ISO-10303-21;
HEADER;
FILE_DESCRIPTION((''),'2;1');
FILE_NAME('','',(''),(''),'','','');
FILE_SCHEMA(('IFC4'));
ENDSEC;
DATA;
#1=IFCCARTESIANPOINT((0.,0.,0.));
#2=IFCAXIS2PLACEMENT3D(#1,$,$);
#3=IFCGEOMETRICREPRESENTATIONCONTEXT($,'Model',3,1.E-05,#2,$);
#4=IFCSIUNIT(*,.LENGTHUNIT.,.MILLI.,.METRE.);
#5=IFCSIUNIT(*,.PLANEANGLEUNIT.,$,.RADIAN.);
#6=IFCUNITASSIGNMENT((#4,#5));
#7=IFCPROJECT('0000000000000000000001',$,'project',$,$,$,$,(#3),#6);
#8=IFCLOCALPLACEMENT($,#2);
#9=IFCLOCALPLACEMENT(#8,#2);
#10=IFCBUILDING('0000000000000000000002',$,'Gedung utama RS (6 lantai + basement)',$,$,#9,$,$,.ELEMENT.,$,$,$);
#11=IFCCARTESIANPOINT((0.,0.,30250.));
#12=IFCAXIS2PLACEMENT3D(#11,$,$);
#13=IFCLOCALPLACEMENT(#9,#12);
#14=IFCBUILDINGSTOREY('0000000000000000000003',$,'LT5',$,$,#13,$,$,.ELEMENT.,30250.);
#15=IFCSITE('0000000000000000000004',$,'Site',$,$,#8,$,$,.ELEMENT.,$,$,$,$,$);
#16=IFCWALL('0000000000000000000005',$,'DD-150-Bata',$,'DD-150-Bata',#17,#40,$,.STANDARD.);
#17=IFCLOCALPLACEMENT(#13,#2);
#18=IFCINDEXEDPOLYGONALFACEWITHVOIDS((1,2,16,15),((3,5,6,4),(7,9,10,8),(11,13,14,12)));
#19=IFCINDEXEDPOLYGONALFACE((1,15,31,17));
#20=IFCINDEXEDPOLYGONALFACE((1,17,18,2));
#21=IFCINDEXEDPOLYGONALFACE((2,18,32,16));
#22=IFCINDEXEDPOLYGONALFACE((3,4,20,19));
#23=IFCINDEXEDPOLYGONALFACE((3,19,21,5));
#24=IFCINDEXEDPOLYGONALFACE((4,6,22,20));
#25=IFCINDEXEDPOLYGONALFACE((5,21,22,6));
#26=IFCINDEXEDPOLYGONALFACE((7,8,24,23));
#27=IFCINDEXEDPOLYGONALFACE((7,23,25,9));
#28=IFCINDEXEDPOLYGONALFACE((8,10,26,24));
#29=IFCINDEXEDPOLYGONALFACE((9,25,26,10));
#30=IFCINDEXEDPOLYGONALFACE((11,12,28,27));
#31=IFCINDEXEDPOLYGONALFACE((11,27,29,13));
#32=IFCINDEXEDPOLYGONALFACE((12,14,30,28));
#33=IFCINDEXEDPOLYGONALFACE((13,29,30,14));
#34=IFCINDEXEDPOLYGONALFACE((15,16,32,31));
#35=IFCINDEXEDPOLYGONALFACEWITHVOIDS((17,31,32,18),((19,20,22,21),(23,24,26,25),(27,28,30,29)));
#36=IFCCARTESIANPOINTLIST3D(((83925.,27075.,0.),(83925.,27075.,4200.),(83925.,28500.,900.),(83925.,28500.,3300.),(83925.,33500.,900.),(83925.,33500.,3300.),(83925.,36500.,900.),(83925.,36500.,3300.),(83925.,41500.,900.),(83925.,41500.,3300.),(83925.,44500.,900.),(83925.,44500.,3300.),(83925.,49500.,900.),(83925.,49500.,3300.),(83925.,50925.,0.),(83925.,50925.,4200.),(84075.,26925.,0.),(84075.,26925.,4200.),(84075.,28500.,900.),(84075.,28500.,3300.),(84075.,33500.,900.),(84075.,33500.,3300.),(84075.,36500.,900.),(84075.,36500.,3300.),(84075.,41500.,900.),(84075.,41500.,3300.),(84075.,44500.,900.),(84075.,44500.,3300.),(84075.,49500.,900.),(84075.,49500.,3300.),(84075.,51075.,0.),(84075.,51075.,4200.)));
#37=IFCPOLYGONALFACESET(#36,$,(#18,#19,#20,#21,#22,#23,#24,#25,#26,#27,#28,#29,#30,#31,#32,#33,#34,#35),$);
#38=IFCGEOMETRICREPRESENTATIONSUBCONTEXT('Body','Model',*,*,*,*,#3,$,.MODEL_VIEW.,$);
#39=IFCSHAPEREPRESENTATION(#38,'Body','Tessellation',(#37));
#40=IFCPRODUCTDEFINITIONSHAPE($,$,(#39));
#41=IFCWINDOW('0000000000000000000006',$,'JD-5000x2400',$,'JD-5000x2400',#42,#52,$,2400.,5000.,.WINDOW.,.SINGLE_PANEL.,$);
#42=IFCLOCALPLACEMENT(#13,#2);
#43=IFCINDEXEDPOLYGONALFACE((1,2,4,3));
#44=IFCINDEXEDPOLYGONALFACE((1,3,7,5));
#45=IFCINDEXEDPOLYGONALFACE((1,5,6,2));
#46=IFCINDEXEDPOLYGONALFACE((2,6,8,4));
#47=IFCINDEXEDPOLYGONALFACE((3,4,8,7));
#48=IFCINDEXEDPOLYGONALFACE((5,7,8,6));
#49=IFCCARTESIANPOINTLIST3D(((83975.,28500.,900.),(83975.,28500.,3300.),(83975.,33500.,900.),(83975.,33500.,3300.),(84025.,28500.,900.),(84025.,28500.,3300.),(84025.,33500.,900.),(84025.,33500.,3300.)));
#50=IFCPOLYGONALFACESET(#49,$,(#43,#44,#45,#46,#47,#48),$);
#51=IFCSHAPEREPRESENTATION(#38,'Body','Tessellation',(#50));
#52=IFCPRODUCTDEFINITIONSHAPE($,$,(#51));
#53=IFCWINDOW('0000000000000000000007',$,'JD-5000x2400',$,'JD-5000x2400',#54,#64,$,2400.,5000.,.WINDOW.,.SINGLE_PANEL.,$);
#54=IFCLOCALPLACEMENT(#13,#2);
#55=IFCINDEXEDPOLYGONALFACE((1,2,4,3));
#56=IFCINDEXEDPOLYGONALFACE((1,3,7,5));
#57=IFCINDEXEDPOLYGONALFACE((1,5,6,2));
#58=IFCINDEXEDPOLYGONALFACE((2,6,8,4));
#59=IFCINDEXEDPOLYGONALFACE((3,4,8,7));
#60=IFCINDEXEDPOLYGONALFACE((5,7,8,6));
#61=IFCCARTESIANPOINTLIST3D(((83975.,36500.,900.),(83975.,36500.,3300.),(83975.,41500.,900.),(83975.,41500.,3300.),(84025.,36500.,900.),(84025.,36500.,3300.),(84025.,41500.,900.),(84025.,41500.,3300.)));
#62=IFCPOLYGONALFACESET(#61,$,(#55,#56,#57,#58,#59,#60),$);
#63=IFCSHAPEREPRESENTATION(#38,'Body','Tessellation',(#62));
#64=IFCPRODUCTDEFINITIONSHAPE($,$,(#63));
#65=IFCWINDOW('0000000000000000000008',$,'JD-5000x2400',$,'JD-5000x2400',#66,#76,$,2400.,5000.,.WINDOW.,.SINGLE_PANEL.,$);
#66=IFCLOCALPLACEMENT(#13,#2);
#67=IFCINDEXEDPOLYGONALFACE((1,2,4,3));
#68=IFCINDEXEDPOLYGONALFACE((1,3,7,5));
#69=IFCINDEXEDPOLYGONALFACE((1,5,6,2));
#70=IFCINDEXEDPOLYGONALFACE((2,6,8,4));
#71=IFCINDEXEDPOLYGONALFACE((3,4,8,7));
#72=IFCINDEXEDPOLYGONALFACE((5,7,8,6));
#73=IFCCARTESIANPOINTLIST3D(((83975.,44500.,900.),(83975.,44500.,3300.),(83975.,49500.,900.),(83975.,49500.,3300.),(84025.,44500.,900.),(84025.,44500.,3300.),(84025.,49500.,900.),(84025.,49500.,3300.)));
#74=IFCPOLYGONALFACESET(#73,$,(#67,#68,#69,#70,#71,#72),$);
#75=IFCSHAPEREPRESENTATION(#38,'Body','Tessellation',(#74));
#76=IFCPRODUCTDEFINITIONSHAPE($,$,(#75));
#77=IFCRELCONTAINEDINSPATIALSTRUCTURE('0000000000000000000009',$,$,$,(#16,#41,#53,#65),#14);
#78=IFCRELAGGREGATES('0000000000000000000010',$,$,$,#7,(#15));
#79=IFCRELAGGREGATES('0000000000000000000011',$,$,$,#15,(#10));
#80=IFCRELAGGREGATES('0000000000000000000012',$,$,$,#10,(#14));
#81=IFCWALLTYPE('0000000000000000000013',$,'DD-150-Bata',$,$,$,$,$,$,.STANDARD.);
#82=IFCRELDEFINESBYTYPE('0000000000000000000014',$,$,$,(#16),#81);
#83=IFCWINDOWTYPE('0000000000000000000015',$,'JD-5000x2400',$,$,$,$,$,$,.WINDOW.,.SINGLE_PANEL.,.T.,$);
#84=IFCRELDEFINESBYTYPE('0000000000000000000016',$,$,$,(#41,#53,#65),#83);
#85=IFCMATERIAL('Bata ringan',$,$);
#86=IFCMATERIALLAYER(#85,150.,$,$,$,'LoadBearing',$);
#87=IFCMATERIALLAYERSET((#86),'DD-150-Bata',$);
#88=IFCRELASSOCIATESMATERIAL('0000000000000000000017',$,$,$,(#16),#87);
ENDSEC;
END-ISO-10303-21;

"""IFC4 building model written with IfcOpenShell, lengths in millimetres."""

from ifc_helpers import new_model, si_unit, frame, frame_2d, origin, place, context, subcontext, project, spatial, polyline, rectangle, outline, extrude, material, layer, layer_set, layer_usage, type_object, element, fill, save


model = new_model("IFC4")

# Units and contexts
model_context = context("Model", 3, precision=1e-05, world=origin())
body_context = subcontext(model_context, "Body", "Model", "MODEL_VIEW")
ifc_project = project(units=[si_unit("LENGTHUNIT", "METRE", prefix="MILLI"), si_unit("PLANEANGLEUNIT", "RADIAN")], contexts=[model_context])

# Site, building, storey
site_placement = place(None, origin())
site = spatial("IfcSite", under=ifc_project, at=site_placement, Name="Site", CompositionType="ELEMENT")
building_placement = place(site_placement, origin())
building = spatial("IfcBuilding", under=site, at=building_placement, Name="Gedung utama RS (6 lantai + basement)", CompositionType="ELEMENT")
storey_placement = place(building_placement, frame((0.0, 0.0, 30250.0)))
storey = spatial("IfcBuildingStorey", under=building, at=storey_placement, Name="LT5", CompositionType="ELEMENT", Elevation=30250.0)

# Wall, openings, windows
ifc_material_1 = material(Name="Bata ringan")
ifc_layer = layer(ifc_material_1, 150.0, Category="LoadBearing")
ifc_layer_set = layer_set([ifc_layer], Name="DD-150-Bata")
ifc_layer_usage = layer_usage(ifc_layer_set, "AXIS2", "NEGATIVE", 75.0)
wall_type = type_object("IfcWallType", Name="DD-150-Bata", PredefinedType="STANDARD")
wall_1_placement = place(storey_placement, frame((84000.0, 27000.0, 0.0), z_axis=(0.0, 0.0, 1.0), x_axis=(0.0, 1.0, 0.0)))
wall_1 = element("IfcWall", 1, at=wall_1_placement, inside=storey, type_object=wall_type, material=ifc_layer_usage, Name="DD-150-Bata", ObjectType="DD-150-Bata", PredefinedType="STANDARD", context=body_context, shape_type="SweptSolid", body=[
    extrude(outline(polyline([(-75.0, -75.0), (0.0, 0.0), (75.0, 75.0), (23925.0, 75.0), (24000.0, 0.0), (24075.0, -75.0), (-75.0, -75.0)])), origin(), (0.0, 0.0, 1.0), 4200.0),
])
opening_1_placement = place(wall_1_placement, frame((1500.0, 0.0, 900.0), z_axis=(0.0, 0.0, 1.0), x_axis=(1.0, 0.0, 0.0)))
opening_1 = element("IfcOpeningElement", 2, at=opening_1_placement, cuts=wall_1, PredefinedType="OPENING", context=body_context, shape_type="SweptSolid", body=[
    extrude(rectangle(XDim=5000.0, YDim=170.0, at=frame_2d((2500.0, 0.0))), origin(), (0.0, 0.0, 1.0), 2400.0),
])
opening_2_placement = place(wall_1_placement, frame((9500.0, 0.0, 900.0), z_axis=(0.0, 0.0, 1.0), x_axis=(1.0, 0.0, 0.0)))
opening_2 = element("IfcOpeningElement", 3, at=opening_2_placement, cuts=wall_1, PredefinedType="OPENING", context=body_context, shape_type="SweptSolid", body=[
    extrude(rectangle(XDim=5000.0, YDim=170.0, at=frame_2d((2500.0, 0.0))), origin(), (0.0, 0.0, 1.0), 2400.0),
])
opening_3_placement = place(wall_1_placement, frame((17500.0, 0.0, 900.0), z_axis=(0.0, 0.0, 1.0), x_axis=(1.0, 0.0, 0.0)))
opening_3 = element("IfcOpeningElement", 4, at=opening_3_placement, cuts=wall_1, PredefinedType="OPENING", context=body_context, shape_type="SweptSolid", body=[
    extrude(rectangle(XDim=5000.0, YDim=170.0, at=frame_2d((2500.0, 0.0))), origin(), (0.0, 0.0, 1.0), 2400.0),
])
window_type = type_object("IfcWindowType", Name="JD-5000x2400", ParameterTakesPrecedence=True, PartitioningType="SINGLE_PANEL", PredefinedType="WINDOW")
window_1_placement = place(opening_1_placement, origin())
window_1 = element("IfcWindow", 5, at=window_1_placement, inside=storey, type_object=window_type, Name="JD-5000x2400", ObjectType="JD-5000x2400", OverallHeight=2400.0, OverallWidth=5000.0, PartitioningType="SINGLE_PANEL", PredefinedType="WINDOW", context=body_context, shape_type="SweptSolid", body=[
    extrude(rectangle(XDim=5000.0, YDim=50.0, at=frame_2d((2500.0, 0.0))), origin(), (0.0, 0.0, 1.0), 2400.0),
])
fill(opening_1, window_1)
window_2_placement = place(opening_2_placement, origin())
window_2 = element("IfcWindow", 6, at=window_2_placement, inside=storey, type_object=window_type, Name="JD-5000x2400", ObjectType="JD-5000x2400", OverallHeight=2400.0, OverallWidth=5000.0, PartitioningType="SINGLE_PANEL", PredefinedType="WINDOW", context=body_context, shape_type="SweptSolid", body=[
    extrude(rectangle(XDim=5000.0, YDim=50.0, at=frame_2d((2500.0, 0.0))), origin(), (0.0, 0.0, 1.0), 2400.0),
])
fill(opening_2, window_2)
window_3_placement = place(opening_3_placement, origin())
window_3 = element("IfcWindow", 7, at=window_3_placement, inside=storey, type_object=window_type, Name="JD-5000x2400", ObjectType="JD-5000x2400", OverallHeight=2400.0, OverallWidth=5000.0, PartitioningType="SINGLE_PANEL", PredefinedType="WINDOW", context=body_context, shape_type="SweptSolid", body=[
    extrude(rectangle(XDim=5000.0, YDim=50.0, at=frame_2d((2500.0, 0.0))), origin(), (0.0, 0.0, 1.0), 2400.0),
])
fill(opening_3, window_3)

save(model, "model.ifc")
